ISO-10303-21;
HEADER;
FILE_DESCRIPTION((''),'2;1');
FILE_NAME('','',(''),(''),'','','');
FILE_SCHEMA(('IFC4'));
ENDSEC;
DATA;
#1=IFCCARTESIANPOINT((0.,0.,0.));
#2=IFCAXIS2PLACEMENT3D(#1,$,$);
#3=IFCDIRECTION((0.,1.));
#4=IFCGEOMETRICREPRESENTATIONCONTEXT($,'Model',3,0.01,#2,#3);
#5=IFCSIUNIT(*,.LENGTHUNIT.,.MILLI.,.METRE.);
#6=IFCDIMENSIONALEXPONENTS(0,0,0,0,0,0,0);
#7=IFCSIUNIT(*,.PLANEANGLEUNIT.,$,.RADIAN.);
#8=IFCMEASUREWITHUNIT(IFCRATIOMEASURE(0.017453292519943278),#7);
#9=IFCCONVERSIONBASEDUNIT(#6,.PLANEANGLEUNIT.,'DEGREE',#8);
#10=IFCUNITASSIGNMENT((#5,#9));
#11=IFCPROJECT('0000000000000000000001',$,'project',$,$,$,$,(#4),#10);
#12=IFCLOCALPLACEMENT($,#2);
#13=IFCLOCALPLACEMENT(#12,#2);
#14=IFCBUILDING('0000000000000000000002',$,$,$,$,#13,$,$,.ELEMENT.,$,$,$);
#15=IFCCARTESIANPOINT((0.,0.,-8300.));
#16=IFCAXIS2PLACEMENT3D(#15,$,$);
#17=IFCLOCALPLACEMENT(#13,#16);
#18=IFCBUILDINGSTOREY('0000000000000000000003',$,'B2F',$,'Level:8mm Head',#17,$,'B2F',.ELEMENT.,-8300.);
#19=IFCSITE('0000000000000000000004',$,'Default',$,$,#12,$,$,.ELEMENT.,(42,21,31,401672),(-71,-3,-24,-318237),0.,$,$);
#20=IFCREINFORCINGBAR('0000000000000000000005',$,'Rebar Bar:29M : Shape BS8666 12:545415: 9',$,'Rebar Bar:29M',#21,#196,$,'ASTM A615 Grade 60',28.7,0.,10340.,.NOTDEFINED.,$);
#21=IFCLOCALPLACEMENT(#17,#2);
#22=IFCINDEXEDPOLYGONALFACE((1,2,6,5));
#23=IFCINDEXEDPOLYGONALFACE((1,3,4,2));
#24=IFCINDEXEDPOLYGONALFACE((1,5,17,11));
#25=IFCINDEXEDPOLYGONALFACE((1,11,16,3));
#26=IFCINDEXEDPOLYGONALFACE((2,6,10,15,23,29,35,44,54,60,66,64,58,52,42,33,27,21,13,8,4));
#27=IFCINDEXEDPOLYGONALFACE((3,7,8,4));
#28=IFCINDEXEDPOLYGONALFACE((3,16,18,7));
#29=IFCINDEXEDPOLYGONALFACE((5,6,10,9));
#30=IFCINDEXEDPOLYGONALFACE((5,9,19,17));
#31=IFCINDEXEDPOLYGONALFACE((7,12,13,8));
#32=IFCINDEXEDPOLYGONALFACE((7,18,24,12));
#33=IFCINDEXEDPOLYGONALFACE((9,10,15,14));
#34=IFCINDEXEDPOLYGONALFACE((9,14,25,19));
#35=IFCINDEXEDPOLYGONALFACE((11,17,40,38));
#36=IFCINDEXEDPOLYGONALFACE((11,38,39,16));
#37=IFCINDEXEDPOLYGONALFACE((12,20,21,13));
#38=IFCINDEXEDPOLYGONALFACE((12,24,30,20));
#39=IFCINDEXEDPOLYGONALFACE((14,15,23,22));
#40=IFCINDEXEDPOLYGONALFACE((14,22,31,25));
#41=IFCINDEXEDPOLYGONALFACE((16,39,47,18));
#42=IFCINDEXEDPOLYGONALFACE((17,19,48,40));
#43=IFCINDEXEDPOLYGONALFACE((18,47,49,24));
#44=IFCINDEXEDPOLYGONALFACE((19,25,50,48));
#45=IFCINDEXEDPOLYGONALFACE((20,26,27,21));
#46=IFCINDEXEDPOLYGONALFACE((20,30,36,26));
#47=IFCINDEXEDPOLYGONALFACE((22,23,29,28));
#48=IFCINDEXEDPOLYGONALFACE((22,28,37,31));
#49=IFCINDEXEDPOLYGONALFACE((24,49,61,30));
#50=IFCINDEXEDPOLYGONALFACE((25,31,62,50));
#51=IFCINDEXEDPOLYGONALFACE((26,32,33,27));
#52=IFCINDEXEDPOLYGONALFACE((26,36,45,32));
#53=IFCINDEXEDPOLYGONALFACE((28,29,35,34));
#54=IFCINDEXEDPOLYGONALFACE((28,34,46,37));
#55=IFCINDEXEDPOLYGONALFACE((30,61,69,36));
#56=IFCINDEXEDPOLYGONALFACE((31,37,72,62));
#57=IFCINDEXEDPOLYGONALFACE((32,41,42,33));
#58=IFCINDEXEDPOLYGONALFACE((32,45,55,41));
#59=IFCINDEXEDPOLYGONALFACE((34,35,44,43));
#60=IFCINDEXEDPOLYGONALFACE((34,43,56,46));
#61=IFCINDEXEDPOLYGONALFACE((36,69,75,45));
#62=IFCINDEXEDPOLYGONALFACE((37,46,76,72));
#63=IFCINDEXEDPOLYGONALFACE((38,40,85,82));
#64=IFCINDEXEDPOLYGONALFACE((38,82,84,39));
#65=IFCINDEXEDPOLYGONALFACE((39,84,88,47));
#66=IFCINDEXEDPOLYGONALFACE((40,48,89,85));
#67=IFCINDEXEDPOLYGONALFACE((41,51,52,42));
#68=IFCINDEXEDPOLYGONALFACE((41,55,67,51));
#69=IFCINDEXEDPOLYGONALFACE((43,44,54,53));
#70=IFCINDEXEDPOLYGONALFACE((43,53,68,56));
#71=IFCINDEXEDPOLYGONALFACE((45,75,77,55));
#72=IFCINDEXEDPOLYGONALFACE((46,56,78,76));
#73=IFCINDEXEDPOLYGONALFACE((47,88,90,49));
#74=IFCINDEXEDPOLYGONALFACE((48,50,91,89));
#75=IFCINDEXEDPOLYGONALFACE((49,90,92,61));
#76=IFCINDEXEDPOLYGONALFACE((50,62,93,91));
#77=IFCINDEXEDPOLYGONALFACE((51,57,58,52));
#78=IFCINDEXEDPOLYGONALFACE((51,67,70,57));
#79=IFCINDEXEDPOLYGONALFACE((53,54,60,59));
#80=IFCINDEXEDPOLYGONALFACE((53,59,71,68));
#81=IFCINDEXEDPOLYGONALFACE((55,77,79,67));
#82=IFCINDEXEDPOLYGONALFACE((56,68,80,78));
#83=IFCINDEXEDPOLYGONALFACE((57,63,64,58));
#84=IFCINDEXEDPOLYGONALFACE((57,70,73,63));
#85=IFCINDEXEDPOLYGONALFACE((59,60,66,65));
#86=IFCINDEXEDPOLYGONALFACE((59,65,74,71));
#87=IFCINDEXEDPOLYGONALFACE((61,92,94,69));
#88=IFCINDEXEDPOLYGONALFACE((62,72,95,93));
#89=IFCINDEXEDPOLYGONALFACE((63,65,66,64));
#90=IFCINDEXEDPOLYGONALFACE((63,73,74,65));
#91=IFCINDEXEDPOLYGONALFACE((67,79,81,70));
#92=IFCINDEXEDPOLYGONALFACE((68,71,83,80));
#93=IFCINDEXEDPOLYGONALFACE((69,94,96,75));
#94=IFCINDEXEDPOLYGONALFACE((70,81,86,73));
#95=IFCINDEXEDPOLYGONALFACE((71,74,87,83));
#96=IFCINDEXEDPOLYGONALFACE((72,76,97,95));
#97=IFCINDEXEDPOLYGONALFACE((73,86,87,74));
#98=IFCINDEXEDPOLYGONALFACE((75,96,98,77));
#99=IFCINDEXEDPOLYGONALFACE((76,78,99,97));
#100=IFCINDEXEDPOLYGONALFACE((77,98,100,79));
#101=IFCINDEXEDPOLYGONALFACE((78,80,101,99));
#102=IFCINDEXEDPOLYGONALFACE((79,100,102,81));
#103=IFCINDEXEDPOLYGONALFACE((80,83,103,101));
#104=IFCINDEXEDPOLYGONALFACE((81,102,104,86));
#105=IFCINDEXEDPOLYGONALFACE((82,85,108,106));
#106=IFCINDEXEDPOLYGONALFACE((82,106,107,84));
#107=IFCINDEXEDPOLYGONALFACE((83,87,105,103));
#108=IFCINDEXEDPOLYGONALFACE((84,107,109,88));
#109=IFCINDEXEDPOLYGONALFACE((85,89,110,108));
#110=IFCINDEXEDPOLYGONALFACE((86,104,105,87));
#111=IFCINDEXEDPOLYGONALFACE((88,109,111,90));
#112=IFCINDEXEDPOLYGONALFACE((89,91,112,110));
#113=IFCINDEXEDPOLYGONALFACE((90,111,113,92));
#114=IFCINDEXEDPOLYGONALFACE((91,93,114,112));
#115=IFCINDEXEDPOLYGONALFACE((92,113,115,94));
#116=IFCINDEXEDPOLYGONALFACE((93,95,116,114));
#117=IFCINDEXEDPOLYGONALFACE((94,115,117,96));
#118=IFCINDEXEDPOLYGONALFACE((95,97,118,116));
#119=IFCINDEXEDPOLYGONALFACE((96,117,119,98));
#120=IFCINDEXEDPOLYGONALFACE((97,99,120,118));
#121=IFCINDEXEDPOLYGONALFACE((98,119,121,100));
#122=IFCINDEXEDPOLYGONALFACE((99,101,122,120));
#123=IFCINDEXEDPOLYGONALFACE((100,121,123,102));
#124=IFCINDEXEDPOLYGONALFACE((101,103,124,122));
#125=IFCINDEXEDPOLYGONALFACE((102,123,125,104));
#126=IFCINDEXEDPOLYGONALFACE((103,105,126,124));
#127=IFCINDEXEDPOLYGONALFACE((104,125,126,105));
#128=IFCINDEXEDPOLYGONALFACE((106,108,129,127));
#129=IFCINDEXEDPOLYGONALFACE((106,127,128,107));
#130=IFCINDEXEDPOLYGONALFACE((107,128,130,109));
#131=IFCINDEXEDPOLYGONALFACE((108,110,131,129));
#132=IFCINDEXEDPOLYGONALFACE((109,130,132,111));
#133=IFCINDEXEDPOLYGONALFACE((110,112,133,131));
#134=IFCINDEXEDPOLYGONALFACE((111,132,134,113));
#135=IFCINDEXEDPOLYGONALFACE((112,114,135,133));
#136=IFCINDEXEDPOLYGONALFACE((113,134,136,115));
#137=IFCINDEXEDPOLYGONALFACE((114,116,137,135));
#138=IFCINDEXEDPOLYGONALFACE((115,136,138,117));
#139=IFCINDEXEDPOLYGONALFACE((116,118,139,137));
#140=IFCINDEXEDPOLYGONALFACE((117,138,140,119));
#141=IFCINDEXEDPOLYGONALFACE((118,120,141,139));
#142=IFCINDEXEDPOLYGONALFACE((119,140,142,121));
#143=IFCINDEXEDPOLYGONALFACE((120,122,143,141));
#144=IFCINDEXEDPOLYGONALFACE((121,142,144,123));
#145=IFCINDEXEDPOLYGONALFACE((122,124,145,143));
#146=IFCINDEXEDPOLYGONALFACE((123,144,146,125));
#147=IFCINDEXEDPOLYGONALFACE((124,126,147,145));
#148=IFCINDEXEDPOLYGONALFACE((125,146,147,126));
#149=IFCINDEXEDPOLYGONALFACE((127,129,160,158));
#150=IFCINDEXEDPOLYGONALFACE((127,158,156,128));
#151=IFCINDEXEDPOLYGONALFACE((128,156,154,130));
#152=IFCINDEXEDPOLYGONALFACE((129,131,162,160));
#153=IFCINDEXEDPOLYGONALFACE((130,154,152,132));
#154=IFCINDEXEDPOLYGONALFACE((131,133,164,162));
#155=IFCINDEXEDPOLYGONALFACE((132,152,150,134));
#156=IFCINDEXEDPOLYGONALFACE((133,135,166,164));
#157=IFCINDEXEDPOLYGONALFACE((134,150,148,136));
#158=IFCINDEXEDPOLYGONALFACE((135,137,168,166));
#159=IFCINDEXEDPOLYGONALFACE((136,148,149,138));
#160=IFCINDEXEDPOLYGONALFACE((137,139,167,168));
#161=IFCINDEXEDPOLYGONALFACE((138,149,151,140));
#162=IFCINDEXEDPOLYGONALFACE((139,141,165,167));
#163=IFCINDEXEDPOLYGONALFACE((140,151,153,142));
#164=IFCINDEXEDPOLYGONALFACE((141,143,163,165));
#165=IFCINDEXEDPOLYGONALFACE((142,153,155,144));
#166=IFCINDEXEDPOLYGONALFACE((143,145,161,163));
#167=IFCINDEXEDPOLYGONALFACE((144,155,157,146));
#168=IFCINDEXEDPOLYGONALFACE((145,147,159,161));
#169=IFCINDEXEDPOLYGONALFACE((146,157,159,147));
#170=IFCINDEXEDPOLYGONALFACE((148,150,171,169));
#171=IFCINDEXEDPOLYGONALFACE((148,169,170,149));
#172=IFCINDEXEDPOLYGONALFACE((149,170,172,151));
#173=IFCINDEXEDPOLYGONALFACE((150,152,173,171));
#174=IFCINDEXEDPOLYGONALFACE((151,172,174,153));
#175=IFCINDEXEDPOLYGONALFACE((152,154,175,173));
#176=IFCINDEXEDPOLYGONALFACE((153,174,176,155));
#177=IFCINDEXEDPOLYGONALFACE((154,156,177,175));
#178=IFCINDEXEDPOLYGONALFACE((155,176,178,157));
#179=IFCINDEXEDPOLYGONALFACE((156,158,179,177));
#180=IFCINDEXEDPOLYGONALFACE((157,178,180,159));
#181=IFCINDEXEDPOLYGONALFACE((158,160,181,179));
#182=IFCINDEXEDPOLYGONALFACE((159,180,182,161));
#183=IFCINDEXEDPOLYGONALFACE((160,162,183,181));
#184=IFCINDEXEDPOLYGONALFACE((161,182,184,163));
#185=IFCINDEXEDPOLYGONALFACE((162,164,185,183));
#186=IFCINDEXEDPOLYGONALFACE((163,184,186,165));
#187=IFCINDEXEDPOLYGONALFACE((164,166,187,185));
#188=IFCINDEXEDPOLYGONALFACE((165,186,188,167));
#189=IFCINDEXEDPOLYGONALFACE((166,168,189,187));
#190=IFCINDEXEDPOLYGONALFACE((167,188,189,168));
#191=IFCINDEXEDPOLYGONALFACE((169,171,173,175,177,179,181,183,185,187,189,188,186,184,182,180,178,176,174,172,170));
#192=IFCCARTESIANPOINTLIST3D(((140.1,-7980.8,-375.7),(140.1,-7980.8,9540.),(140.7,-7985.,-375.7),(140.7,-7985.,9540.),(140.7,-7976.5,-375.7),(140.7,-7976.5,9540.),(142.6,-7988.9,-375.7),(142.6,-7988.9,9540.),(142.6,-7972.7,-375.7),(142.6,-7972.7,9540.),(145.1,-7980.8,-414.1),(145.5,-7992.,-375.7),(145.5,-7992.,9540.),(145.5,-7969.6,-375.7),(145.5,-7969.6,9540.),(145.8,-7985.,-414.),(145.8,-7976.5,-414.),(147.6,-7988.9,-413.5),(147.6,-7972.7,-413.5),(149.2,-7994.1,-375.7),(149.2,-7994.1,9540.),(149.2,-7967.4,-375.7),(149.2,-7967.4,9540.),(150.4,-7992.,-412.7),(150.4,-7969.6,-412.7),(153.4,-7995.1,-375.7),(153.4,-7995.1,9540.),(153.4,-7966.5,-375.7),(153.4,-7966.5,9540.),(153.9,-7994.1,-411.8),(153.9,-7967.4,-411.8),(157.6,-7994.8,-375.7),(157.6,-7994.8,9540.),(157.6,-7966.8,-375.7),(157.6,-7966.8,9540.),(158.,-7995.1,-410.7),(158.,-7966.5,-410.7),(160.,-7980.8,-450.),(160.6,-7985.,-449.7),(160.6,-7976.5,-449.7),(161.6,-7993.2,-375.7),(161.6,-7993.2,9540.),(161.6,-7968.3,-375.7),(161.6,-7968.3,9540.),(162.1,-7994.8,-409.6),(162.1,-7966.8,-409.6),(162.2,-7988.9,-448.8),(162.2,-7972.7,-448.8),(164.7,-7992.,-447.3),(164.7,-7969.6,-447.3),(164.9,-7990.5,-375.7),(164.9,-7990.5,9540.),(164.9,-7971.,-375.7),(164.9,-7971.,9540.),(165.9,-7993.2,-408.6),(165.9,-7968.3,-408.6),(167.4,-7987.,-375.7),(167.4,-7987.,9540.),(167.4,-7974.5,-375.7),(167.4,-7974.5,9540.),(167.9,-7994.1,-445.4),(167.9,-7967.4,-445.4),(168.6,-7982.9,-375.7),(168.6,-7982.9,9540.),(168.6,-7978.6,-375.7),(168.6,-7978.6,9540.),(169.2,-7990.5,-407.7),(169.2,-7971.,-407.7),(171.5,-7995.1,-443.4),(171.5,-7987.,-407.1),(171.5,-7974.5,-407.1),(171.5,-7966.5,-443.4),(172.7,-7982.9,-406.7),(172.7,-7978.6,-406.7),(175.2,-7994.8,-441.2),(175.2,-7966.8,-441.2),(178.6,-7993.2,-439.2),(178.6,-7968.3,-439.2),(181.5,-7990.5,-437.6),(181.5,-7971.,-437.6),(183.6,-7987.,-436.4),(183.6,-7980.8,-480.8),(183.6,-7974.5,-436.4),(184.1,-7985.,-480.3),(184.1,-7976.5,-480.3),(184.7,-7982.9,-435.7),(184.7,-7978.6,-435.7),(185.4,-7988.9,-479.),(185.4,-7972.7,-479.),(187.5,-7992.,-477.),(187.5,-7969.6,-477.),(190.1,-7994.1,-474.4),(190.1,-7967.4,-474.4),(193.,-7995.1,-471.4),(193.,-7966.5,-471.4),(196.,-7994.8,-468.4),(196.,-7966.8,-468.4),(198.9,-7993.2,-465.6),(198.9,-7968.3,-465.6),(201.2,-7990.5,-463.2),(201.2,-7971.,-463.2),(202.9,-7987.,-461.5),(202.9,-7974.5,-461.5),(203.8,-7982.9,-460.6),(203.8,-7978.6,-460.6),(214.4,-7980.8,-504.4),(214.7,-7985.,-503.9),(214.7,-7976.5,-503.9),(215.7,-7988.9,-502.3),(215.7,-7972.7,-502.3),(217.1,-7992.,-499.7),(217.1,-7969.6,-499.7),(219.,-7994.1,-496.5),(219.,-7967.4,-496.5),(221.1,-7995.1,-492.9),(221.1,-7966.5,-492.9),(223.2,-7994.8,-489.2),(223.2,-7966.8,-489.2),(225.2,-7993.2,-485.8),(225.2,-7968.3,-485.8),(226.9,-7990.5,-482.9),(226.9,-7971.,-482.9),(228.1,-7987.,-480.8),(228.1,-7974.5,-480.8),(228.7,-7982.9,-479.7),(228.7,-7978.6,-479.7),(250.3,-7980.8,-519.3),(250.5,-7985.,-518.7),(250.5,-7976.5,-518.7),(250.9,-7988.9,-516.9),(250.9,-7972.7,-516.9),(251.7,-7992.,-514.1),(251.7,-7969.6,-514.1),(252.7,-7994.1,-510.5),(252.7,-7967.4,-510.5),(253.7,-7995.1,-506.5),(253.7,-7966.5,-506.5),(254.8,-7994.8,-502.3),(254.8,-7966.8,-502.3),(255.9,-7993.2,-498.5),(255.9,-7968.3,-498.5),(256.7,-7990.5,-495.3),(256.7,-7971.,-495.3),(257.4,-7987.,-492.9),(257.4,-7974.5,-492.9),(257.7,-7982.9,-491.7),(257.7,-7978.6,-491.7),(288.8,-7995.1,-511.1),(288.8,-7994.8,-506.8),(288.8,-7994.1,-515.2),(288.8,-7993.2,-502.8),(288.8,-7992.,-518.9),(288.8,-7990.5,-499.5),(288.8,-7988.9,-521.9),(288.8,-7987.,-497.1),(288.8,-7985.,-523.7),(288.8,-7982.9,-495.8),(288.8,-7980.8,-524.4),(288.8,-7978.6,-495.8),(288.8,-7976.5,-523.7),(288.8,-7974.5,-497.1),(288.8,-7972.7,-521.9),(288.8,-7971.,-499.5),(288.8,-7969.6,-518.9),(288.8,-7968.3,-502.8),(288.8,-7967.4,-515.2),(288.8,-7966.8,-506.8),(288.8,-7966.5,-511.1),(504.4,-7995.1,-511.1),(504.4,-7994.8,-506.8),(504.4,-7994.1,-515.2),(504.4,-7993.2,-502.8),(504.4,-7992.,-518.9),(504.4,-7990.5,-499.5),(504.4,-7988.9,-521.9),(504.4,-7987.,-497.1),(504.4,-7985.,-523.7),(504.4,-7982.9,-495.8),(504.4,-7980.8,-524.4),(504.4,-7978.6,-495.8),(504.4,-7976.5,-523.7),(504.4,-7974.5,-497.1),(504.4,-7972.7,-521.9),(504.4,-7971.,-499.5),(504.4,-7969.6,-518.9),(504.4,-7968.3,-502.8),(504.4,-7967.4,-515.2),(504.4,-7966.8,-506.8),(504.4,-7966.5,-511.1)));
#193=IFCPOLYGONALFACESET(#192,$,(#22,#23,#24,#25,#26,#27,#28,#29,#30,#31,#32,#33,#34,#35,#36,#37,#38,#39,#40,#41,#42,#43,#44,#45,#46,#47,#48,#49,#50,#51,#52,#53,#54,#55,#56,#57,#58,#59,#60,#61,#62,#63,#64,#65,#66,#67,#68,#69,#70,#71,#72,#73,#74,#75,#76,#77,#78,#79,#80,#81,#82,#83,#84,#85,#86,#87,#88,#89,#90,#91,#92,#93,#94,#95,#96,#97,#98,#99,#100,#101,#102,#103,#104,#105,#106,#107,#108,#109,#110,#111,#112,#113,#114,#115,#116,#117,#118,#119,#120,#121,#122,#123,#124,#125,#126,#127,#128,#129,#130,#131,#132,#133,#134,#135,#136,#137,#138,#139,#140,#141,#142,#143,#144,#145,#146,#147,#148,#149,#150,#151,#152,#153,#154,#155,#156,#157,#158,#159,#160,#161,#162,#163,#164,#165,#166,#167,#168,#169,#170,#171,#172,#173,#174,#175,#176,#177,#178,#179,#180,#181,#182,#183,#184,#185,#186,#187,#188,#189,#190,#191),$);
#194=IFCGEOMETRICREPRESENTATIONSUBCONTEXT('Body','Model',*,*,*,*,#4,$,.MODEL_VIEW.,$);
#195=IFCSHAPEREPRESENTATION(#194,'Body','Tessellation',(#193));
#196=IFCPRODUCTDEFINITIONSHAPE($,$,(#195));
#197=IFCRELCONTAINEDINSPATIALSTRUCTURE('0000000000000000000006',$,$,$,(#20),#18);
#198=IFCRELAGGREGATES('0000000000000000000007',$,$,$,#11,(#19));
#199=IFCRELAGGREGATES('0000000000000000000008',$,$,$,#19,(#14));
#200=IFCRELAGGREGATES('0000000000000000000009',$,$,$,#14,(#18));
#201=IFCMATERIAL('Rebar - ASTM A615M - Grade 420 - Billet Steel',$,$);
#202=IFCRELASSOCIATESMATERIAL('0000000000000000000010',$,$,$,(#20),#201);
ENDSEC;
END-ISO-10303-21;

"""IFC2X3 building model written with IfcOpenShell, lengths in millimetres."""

from ifc_helpers import new_model, entity, si_unit, converted_unit, direction, frame, origin, place, context, subcontext, project, spatial, material, element, save


model = new_model("IFC2X3")

# Units and contexts
model_context = context("Model", 3, precision=0.01, world=origin(), true_north=direction((0.0, 1.0)))
body_context = subcontext(model_context, "Body", "Model", "MODEL_VIEW")
ifc_project = project(units=[si_unit("LENGTHUNIT", "METRE", prefix="MILLI"), converted_unit("PLANEANGLEUNIT", "DEGREE", entity("IfcRatioMeasure", 0.017453292519943278), si_unit("PLANEANGLEUNIT", "RADIAN"), dimensions=[0, 0, 0, 0, 0, 0, 0])], contexts=[model_context])

# Site, building, storey
site_placement = place(None, origin())
site = spatial("IfcSite", under=ifc_project, at=site_placement, Name="Default", CompositionType="ELEMENT", RefLatitude=(42, 21, 31, 401672), RefLongitude=(-71, -3, -24, -318237), RefElevation=0.0)
building_placement = place(site_placement, origin())
building = spatial("IfcBuilding", under=site, at=building_placement, CompositionType="ELEMENT")
storey_placement = place(building_placement, frame((0.0, 0.0, -8300.0)))
storey = spatial("IfcBuildingStorey", under=building, at=storey_placement, Name="B2F", ObjectType="Level:8mm Head", LongName="B2F", CompositionType="ELEMENT", Elevation=-8300.0)

# Reinforcing bar
ifc_material_1 = material(Name="Rebar - ASTM A615M - Grade 420 - Billet Steel")
reinforcing_bar_1_placement = place(storey_placement, origin())
element("IfcReinforcingBar", 1, at=reinforcing_bar_1_placement, inside=storey, material=ifc_material_1, Name="Rebar Bar:29M : Shape BS8666 12:545415: 9", SteelGrade="ASTM A615 Grade 60", ObjectType="Rebar Bar:29M", BarLength=10340.0, BarRole="NOTDEFINED", CrossSectionArea=0.0, NominalDiameter=28.7, context=body_context, shape_type="AdvancedSweptSolid", body=[
    entity("IfcSweptDiskSolid", entity("IfcCompositeCurve", [entity("IfcCompositeCurveSegment", "CONTINUOUS", True, entity("IfcPolyline", [entity("IfcCartesianPoint", [154.4, -7980.8, 9540.0]), entity("IfcCartesianPoint", [154.4, -7980.8, -375.7])])), entity("IfcCompositeCurveSegment", "CONTINUOUS", True, entity("IfcTrimmedCurve", entity("IfcCircle", entity("IfcAxis2Placement3D", entity("IfcCartesianPoint", [288.8, -7980.8, -375.7]), entity("IfcDirection", [0.0, -1.0, 0.0]), entity("IfcDirection", [0.0, 0.0, -1.0])), 134.3), [entity("IfcParameterValue", 270.0)], [entity("IfcParameterValue", 360.0)], True, "PARAMETER")), entity("IfcCompositeCurveSegment", "CONTINUOUS", True, entity("IfcPolyline", [entity("IfcCartesianPoint", [288.8, -7980.8, -510.0]), entity("IfcCartesianPoint", [504.4, -7980.8, -510.0])]))], False), 14.3, None, 0.0, 92.0),
])

save(model, "model.ifc")
